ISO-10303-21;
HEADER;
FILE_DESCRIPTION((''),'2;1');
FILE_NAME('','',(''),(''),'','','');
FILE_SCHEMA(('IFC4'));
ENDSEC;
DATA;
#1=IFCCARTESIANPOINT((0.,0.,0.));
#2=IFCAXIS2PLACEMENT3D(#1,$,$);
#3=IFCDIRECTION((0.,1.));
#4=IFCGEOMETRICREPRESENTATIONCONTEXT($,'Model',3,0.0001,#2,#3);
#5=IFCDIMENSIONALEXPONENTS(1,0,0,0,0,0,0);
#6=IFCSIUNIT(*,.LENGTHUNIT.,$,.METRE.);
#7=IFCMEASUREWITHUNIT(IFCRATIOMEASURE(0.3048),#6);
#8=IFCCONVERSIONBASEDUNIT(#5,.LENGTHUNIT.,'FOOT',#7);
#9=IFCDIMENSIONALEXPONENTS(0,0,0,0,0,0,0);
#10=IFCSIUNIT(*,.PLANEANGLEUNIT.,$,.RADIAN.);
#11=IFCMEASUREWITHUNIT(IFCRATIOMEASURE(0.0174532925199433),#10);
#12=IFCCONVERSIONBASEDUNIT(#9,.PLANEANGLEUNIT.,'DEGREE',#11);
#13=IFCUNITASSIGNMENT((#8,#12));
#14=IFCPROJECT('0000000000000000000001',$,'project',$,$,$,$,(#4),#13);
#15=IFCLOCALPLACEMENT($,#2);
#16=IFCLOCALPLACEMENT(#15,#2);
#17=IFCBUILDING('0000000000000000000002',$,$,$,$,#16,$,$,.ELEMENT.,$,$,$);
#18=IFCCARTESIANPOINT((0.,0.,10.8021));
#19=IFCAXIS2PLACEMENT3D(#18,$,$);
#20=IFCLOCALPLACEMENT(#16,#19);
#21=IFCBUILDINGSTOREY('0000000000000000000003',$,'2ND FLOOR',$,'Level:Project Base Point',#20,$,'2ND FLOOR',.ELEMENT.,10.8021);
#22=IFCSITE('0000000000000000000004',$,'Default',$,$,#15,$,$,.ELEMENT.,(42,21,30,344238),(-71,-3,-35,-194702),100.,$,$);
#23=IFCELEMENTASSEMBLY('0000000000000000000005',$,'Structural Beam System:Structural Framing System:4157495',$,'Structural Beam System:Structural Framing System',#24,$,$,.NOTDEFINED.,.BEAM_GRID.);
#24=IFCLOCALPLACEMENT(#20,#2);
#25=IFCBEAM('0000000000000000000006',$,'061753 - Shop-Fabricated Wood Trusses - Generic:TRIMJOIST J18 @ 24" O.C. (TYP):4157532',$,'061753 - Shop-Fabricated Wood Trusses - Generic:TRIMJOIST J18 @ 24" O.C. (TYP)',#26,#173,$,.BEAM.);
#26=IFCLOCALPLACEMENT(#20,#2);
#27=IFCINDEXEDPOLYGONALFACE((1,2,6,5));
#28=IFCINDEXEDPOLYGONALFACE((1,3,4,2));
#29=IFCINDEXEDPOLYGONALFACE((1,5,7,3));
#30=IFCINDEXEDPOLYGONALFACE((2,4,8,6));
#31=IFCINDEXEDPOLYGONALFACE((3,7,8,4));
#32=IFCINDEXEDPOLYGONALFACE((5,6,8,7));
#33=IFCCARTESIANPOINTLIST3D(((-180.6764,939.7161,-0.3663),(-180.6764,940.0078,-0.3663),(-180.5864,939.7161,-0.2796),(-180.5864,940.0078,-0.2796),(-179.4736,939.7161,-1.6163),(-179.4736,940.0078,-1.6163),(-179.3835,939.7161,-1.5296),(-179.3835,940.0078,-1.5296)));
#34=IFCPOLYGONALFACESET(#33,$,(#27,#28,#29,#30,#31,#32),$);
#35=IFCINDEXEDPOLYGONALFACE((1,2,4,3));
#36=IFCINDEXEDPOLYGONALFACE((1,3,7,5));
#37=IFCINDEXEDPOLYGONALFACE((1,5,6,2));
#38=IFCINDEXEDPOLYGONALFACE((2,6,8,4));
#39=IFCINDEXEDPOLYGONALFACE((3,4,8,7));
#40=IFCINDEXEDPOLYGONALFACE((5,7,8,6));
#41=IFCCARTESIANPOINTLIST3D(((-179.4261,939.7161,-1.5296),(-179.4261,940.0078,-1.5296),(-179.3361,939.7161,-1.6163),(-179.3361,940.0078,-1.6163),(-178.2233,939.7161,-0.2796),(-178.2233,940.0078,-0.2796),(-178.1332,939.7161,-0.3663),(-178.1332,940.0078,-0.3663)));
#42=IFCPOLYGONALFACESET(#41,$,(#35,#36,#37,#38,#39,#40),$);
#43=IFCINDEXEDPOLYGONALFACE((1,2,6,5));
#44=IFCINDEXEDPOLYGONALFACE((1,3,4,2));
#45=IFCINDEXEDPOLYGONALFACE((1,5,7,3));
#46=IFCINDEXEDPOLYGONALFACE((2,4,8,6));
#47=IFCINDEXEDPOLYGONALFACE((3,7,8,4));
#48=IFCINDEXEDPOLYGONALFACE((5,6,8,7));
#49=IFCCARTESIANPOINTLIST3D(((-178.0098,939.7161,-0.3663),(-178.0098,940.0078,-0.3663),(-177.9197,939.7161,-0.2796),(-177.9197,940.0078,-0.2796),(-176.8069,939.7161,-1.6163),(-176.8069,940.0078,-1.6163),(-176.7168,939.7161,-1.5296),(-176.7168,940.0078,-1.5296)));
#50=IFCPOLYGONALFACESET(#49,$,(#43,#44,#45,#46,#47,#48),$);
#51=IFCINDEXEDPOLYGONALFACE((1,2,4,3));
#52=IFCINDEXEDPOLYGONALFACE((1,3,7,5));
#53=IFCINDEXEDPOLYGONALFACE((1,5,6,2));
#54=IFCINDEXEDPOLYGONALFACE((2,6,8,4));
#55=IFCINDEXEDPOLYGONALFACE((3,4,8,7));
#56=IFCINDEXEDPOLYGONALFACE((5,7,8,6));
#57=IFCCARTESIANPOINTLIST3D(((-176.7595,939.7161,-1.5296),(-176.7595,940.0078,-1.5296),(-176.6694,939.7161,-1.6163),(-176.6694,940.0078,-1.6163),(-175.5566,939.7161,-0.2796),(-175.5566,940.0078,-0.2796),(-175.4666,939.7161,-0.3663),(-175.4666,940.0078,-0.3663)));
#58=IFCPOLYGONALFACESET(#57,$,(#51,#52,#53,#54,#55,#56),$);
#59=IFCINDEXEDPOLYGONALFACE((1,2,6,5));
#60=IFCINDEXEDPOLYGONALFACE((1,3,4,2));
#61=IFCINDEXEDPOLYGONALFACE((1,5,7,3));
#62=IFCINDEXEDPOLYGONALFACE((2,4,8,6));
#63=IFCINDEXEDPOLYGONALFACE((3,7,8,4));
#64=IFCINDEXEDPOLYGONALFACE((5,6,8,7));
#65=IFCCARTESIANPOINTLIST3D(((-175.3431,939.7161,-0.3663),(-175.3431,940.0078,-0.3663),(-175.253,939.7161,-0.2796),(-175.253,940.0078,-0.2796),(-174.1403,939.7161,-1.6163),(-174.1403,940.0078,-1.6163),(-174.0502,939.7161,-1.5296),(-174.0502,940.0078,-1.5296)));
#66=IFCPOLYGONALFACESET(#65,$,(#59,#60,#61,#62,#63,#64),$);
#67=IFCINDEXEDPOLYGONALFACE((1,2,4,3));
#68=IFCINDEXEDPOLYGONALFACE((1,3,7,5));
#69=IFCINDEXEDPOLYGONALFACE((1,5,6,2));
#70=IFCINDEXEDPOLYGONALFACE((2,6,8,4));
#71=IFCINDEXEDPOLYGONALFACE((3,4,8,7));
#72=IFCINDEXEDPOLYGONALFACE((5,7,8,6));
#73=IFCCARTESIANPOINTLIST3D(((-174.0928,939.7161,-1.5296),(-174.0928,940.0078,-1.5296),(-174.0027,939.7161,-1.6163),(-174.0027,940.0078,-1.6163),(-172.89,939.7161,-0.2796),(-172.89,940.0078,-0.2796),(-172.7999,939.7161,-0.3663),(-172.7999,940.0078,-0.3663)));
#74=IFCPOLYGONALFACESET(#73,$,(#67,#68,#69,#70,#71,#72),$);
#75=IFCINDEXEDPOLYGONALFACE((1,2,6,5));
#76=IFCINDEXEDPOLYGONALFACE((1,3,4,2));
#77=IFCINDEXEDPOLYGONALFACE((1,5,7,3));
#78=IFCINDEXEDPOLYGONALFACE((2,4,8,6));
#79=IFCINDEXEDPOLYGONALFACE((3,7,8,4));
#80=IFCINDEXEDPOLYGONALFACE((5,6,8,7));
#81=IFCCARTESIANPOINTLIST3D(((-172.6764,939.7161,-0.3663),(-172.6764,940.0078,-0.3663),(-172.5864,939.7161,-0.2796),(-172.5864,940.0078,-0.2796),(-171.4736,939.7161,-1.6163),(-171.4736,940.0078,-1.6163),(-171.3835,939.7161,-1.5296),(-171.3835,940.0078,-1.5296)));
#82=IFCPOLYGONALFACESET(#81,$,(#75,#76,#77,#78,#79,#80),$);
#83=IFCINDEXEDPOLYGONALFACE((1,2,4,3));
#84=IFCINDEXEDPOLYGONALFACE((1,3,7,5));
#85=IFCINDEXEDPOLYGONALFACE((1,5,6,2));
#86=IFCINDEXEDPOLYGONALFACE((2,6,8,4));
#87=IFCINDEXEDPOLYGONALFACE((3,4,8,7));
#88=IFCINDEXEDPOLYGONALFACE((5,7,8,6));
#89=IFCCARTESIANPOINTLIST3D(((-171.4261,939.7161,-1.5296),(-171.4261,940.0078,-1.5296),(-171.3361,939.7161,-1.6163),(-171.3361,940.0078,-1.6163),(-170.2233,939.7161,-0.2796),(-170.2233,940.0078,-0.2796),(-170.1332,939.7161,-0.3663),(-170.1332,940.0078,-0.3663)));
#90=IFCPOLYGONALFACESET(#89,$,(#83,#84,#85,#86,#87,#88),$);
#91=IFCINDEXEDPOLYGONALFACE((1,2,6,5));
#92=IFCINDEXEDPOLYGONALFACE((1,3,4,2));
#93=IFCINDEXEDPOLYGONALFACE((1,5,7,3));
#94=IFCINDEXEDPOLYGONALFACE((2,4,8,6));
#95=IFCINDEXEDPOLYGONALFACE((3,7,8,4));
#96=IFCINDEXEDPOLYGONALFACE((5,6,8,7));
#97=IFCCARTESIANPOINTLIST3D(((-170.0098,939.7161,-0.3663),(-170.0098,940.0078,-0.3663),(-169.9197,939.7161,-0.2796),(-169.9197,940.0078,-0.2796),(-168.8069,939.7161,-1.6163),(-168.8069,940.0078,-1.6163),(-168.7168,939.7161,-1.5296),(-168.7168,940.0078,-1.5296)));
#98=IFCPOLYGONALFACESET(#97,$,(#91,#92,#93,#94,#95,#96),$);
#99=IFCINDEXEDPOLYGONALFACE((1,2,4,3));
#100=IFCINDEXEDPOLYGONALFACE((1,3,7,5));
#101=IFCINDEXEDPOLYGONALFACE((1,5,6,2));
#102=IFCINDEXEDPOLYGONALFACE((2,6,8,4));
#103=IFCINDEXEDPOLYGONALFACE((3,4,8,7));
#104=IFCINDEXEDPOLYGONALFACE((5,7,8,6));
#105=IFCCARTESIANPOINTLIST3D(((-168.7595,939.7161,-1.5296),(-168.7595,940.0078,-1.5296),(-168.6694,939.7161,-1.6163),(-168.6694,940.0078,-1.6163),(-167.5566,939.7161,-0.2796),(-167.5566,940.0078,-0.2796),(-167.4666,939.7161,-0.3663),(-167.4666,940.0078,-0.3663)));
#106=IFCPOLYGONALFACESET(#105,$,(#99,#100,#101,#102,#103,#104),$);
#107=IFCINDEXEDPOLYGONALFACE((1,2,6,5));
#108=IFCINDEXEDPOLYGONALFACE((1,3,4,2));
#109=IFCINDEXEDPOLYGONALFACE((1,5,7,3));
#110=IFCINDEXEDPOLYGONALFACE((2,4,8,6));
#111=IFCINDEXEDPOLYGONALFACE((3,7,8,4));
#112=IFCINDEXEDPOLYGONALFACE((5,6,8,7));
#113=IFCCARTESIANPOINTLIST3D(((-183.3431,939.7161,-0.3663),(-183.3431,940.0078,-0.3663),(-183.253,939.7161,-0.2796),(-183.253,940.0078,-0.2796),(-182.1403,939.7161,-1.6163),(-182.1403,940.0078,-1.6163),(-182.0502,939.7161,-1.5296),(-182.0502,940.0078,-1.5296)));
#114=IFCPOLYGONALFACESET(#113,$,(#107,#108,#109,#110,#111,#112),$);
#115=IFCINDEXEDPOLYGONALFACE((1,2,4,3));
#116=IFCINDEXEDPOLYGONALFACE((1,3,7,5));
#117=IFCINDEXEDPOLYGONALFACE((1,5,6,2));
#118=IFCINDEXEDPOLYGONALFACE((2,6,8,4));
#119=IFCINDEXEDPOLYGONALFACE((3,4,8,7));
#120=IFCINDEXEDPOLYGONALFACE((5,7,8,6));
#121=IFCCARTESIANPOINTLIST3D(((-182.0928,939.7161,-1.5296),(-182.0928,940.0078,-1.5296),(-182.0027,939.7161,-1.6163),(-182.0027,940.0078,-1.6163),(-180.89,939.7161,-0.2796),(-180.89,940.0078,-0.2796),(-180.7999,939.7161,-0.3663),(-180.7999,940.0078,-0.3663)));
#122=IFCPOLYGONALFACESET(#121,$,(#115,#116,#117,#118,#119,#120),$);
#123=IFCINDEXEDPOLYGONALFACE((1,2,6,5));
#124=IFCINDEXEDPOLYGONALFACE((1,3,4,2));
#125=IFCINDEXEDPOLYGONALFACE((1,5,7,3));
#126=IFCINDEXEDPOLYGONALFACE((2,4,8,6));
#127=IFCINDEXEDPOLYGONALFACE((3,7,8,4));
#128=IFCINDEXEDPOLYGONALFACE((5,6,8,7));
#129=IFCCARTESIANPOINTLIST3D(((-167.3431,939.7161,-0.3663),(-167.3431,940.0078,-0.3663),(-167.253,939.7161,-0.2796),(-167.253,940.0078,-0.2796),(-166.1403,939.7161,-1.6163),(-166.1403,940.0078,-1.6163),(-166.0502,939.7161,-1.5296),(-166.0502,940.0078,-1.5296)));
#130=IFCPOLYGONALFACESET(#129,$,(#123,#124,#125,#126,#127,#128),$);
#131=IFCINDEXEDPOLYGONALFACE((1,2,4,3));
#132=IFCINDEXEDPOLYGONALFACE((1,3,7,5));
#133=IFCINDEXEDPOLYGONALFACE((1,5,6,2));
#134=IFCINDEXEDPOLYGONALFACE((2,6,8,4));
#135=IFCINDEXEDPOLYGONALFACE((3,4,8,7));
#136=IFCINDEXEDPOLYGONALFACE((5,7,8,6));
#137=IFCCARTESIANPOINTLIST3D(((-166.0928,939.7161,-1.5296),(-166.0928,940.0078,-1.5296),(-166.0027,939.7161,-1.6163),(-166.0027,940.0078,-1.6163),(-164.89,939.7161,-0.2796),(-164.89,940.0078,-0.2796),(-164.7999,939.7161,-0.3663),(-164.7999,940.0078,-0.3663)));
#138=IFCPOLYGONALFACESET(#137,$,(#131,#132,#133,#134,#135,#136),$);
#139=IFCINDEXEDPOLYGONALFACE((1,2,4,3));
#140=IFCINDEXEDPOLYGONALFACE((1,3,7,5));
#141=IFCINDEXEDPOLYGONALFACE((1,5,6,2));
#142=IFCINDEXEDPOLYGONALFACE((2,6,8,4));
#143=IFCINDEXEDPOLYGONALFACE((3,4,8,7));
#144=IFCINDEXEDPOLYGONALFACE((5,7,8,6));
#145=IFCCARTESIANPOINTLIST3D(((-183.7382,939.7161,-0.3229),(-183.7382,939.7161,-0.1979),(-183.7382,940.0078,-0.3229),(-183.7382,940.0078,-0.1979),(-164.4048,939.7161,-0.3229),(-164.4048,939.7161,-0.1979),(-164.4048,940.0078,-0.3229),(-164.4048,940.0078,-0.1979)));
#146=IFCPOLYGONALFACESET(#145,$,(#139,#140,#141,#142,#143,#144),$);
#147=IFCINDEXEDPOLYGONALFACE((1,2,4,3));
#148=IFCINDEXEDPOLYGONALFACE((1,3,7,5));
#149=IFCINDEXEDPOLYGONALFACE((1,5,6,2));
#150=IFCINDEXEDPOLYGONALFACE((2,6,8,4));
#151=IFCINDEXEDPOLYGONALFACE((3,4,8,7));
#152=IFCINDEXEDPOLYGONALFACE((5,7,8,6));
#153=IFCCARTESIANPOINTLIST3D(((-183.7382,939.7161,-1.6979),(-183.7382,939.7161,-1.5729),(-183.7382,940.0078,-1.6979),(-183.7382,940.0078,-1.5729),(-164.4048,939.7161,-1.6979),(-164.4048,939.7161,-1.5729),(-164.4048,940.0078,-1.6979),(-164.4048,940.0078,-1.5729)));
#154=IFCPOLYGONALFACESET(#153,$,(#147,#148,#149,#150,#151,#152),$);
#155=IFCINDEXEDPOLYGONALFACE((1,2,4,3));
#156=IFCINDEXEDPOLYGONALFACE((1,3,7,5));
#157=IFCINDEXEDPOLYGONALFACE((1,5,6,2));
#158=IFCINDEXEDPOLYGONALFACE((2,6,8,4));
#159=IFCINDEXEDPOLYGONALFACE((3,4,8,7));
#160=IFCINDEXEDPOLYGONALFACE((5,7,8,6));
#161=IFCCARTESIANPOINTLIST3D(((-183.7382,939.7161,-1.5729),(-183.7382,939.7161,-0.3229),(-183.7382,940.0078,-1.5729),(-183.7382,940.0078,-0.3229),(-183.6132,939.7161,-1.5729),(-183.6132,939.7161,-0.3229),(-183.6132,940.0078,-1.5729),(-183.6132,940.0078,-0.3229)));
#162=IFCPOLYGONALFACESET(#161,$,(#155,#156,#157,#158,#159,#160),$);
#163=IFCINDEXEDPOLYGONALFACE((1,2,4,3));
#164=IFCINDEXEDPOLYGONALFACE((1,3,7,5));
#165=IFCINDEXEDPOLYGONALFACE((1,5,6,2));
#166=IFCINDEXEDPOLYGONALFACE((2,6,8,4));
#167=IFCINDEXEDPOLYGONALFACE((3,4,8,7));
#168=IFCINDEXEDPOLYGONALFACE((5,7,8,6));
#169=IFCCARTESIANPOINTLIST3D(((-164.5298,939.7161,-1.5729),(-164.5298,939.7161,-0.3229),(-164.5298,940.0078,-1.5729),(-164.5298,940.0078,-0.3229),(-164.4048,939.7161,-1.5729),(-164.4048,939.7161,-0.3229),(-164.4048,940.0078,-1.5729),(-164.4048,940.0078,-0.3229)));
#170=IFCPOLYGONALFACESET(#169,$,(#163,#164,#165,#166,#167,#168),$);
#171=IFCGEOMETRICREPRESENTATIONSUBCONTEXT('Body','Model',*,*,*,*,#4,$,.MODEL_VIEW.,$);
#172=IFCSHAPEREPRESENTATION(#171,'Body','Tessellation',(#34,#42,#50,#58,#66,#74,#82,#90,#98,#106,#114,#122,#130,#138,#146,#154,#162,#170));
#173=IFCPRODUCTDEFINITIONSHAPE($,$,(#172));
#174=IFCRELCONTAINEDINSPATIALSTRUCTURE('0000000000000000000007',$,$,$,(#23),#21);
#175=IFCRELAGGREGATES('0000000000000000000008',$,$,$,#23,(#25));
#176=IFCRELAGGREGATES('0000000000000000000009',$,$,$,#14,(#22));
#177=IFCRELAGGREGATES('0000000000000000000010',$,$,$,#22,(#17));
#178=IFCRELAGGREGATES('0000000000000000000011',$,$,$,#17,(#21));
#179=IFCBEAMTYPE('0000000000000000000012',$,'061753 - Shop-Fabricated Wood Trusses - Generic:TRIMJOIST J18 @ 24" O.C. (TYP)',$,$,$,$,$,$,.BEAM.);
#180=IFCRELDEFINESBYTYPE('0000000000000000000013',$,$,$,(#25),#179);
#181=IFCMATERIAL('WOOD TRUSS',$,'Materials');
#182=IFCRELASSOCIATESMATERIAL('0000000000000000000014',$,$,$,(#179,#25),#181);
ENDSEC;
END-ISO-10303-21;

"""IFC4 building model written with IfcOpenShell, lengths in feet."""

from ifc_helpers import new_model, entity, si_unit, converted_unit, direction, frame, frame_2d, origin, origin_2d_with_axis, place, context, subcontext, project, spatial, rectangle, extrude, source, transform, mapped, material, material_profile, profile_set, profile_usage, type_object, type_shapes, element, aggregate, save


model = new_model("IFC4")

# Units and contexts
model_context = context("Model", 3, precision=0.0001, world=origin(), true_north=direction((0.0, 1.0)))
body_context = subcontext(model_context, "Body", "Model", "MODEL_VIEW")
ifc_project = project(units=[converted_unit("LENGTHUNIT", "FOOT", entity("IfcRatioMeasure", 0.3048), si_unit("LENGTHUNIT", "METRE"), dimensions=[1, 0, 0, 0, 0, 0, 0]), converted_unit("PLANEANGLEUNIT", "DEGREE", entity("IfcRatioMeasure", 0.0174532925199433), si_unit("PLANEANGLEUNIT", "RADIAN"), dimensions=[0, 0, 0, 0, 0, 0, 0])], contexts=[model_context])

# Site, building, storey
site_placement = place(None, origin())
site = spatial("IfcSite", under=ifc_project, at=site_placement, Name="Default", CompositionType="ELEMENT", RefLatitude=(42, 21, 30, 344238), RefLongitude=(-71, -3, -35, -194702), RefElevation=100.0)
building_placement = place(site_placement, origin())
building = spatial("IfcBuilding", under=site, at=building_placement, CompositionType="ELEMENT")
storey_placement = place(building_placement, frame((0.0, 0.0, 10.8021)))
storey = spatial("IfcBuildingStorey", under=building, at=storey_placement, Name="2ND FLOOR", ObjectType="Level:Project Base Point", LongName="2ND FLOOR", CompositionType="ELEMENT", Elevation=10.8021)

# Element assembly, beam
ifc_material_1 = material(Name="WOOD TRUSS", Category="Materials")
ifc_material_profile_1 = material_profile(ifc_material_1, rectangle(XDim=1.7347, YDim=0.125, at=frame_2d((0.0, 0.0), x_axis=(1.0, 0.0))), Name="TRIMJOIST J18 @ 24\" O.C. (TYP)")
ifc_material_profile_2 = material_profile(ifc_material_1, rectangle(XDim=1.7347, YDim=0.125, at=frame_2d((0.0, 0.0), x_axis=(1.0, 0.0))), Name="TRIMJOIST J18 @ 24\" O.C. (TYP)")
ifc_material_profile_3 = material_profile(ifc_material_1, rectangle(XDim=1.7347, YDim=0.125, at=frame_2d((0.0, 0.0), x_axis=(1.0, 0.0))), Name="TRIMJOIST J18 @ 24\" O.C. (TYP)")
ifc_material_profile_4 = material_profile(ifc_material_1, rectangle(XDim=1.7347, YDim=0.125, at=frame_2d((0.0, 0.0), x_axis=(1.0, 0.0))), Name="TRIMJOIST J18 @ 24\" O.C. (TYP)")
ifc_material_profile_5 = material_profile(ifc_material_1, rectangle(XDim=1.7347, YDim=0.125, at=frame_2d((0.0, 0.0), x_axis=(1.0, 0.0))), Name="TRIMJOIST J18 @ 24\" O.C. (TYP)")
ifc_material_profile_6 = material_profile(ifc_material_1, rectangle(XDim=1.7347, YDim=0.125, at=frame_2d((0.0, 0.0), x_axis=(1.0, 0.0))), Name="TRIMJOIST J18 @ 24\" O.C. (TYP)")
ifc_material_profile_7 = material_profile(ifc_material_1, rectangle(XDim=1.7347, YDim=0.125, at=frame_2d((0.0, 0.0), x_axis=(1.0, 0.0))), Name="TRIMJOIST J18 @ 24\" O.C. (TYP)")
ifc_material_profile_8 = material_profile(ifc_material_1, rectangle(XDim=1.7347, YDim=0.125, at=frame_2d((0.0, 0.0), x_axis=(1.0, 0.0))), Name="TRIMJOIST J18 @ 24\" O.C. (TYP)")
ifc_material_profile_9 = material_profile(ifc_material_1, rectangle(XDim=1.7347, YDim=0.125, at=frame_2d((0.0, 0.0), x_axis=(1.0, 0.0))), Name="TRIMJOIST J18 @ 24\" O.C. (TYP)")
ifc_material_profile_10 = material_profile(ifc_material_1, rectangle(XDim=1.7347, YDim=0.125, at=origin_2d_with_axis()), Name="TRIMJOIST J18 @ 24\" O.C. (TYP)")
ifc_material_profile_11 = material_profile(ifc_material_1, rectangle(XDim=0.125, YDim=0.2917, at=origin_2d_with_axis()), Name="TRIMJOIST J18 @ 24\" O.C. (TYP)")
ifc_material_profile_12 = material_profile(ifc_material_1, rectangle(XDim=0.125, YDim=0.2917, at=origin_2d_with_axis()), Name="TRIMJOIST J18 @ 24\" O.C. (TYP)")
ifc_material_profile_13 = material_profile(ifc_material_1, rectangle(XDim=1.25, YDim=0.2917, at=origin_2d_with_axis()), Name="TRIMJOIST J18 @ 24\" O.C. (TYP)")
ifc_material_profile_14 = material_profile(ifc_material_1, rectangle(XDim=1.25, YDim=0.2917, at=origin_2d_with_axis()), Name="TRIMJOIST J18 @ 24\" O.C. (TYP)")
ifc_profile_set_1 = profile_set([ifc_material_profile_1, ifc_material_profile_2, ifc_material_profile_3, ifc_material_profile_4, ifc_material_profile_5, ifc_material_profile_6, ifc_material_profile_7, ifc_material_profile_8, ifc_material_profile_9, ifc_material_profile_10, ifc_material_profile_11, ifc_material_profile_12, ifc_material_profile_13, ifc_material_profile_14], Name="TRIMJOIST J18 @ 24\" O.C. (TYP)")
assembly_1_placement = place(storey_placement, origin())
assembly_1 = element("IfcElementAssembly", 1, at=assembly_1_placement, inside=storey, Name="Structural Beam System:Structural Framing System:4157495", ObjectType="Structural Beam System:Structural Framing System", AssemblyPlace="NOTDEFINED", PredefinedType="BEAM_GRID")
ifc_profile_usage_1 = profile_usage(ifc_profile_set_1, cardinal=8)
beam_type_1 = type_object("IfcBeamType", Name="061753 - Shop-Fabricated Wood Trusses - Generic:TRIMJOIST J18 @ 24\" O.C. (TYP)", PredefinedType="BEAM", material=ifc_profile_set_1)
shared_shape_1 = source(origin(), body_context, "Body", "SweptSolid", [
    extrude(rectangle(XDim=1.7347, YDim=0.125, at=frame_2d((0.0, 0.0), x_axis=(1.0, 0.0))), frame((5.9585, -0.1458, 0.0), z_axis=(0.0, 1.0, 0.0), x_axis=(0.693383, 0.0, 0.720569)), (0.0, 0.0, 1.0), 0.2917),
    extrude(rectangle(XDim=1.7347, YDim=0.125, at=origin_2d_with_axis()), frame((4.7082, -0.1458, 0.0), z_axis=(0.0, 1.0, 0.0), x_axis=(0.693383, 0.0, -0.720569)), (0.0, 0.0, 1.0), 0.2917),
    extrude(rectangle(XDim=1.7347, YDim=0.125, at=frame_2d((0.0, 0.0), x_axis=(1.0, 0.0))), frame((3.2918, -0.1458, 0.0), z_axis=(0.0, 1.0, 0.0), x_axis=(0.693383, 0.0, 0.720569)), (0.0, 0.0, 1.0), 0.2917),
    extrude(rectangle(XDim=1.7347, YDim=0.125, at=frame_2d((0.0, 0.0), x_axis=(1.0, 0.0))), frame((2.0415, -0.1458, 0.0), z_axis=(0.0, 1.0, 0.0), x_axis=(0.693383, 0.0, -0.720569)), (0.0, 0.0, 1.0), 0.2917),
    extrude(rectangle(XDim=1.7347, YDim=0.125, at=frame_2d((0.0, 0.0), x_axis=(1.0, 0.0))), frame((0.6251, -0.1458, 0.0), z_axis=(0.0, 1.0, 0.0), x_axis=(0.693383, 0.0, 0.720569)), (0.0, 0.0, 1.0), 0.2917),
    extrude(rectangle(XDim=1.7347, YDim=0.125, at=frame_2d((0.0, 0.0), x_axis=(1.0, 0.0))), frame((-0.6251, -0.1458, 0.0), z_axis=(0.0, 1.0, 0.0), x_axis=(0.693383, 0.0, -0.720569)), (0.0, 0.0, 1.0), 0.2917),
    extrude(rectangle(XDim=1.7347, YDim=0.125, at=frame_2d((0.0, 0.0), x_axis=(1.0, 0.0))), frame((-2.0415, -0.1458, 0.0), z_axis=(0.0, 1.0, 0.0), x_axis=(0.693383, 0.0, 0.720569)), (0.0, 0.0, 1.0), 0.2917),
    extrude(rectangle(XDim=1.7347, YDim=0.125, at=origin_2d_with_axis()), frame((-3.2918, -0.1458, 0.0), z_axis=(0.0, 1.0, 0.0), x_axis=(0.693383, 0.0, -0.720569)), (0.0, 0.0, 1.0), 0.2917),
    extrude(rectangle(XDim=1.7347, YDim=0.125, at=frame_2d((0.0, 0.0), x_axis=(1.0, 0.0))), frame((-4.7082, -0.1458, 0.0), z_axis=(0.0, 1.0, 0.0), x_axis=(0.693383, 0.0, 0.720569)), (0.0, 0.0, 1.0), 0.2917),
    extrude(rectangle(XDim=1.7347, YDim=0.125, at=frame_2d((0.0, 0.0), x_axis=(1.0, 0.0))), frame((-5.9585, -0.1458, 0.0), z_axis=(0.0, 1.0, 0.0), x_axis=(0.693383, 0.0, -0.720569)), (0.0, 0.0, 1.0), 0.2917),
    extrude(rectangle(XDim=1.7347, YDim=0.125, at=frame_2d((0.0, 0.0), x_axis=(1.0, 0.0))), frame((8.6251, -0.1458, 0.0), z_axis=(0.0, 1.0, 0.0), x_axis=(0.693383, 0.0, 0.720569)), (0.0, 0.0, 1.0), 0.2917),
    extrude(rectangle(XDim=1.7347, YDim=0.125, at=origin_2d_with_axis()), frame((7.3749, -0.1458, 0.0), z_axis=(0.0, 1.0, 0.0), x_axis=(0.693383, 0.0, -0.720569)), (0.0, 0.0, 1.0), 0.2917),
    extrude(rectangle(XDim=1.7347, YDim=0.125, at=frame_2d((0.0, 0.0), x_axis=(1.0, 0.0))), frame((-7.3749, -0.1458, 0.0), z_axis=(0.0, 1.0, 0.0), x_axis=(0.693383, 0.0, 0.720569)), (0.0, 0.0, 1.0), 0.2917),
    extrude(rectangle(XDim=1.7347, YDim=0.125, at=origin_2d_with_axis()), frame((-8.6251, -0.1458, 0.0), z_axis=(0.0, 1.0, 0.0), x_axis=(0.693383, 0.0, -0.720569)), (0.0, 0.0, 1.0), 0.2917),
    extrude(rectangle(XDim=0.125, YDim=0.2917, at=origin_2d_with_axis()), frame((-9.6667, 0.0, 0.6875), z_axis=(1.0, 0.0, 0.0), x_axis=(0.0, 0.0, -1.0)), (0.0, 0.0, 1.0), 19.3333),
    extrude(rectangle(XDim=0.125, YDim=0.2917, at=origin_2d_with_axis()), frame((-9.6667, 0.0, -0.6875), z_axis=(1.0, 0.0, 0.0), x_axis=(0.0, 0.0, -1.0)), (0.0, 0.0, 1.0), 19.3333),
    extrude(rectangle(XDim=1.25, YDim=0.2917, at=origin_2d_with_axis()), frame((9.5417, 0.0, 0.0), z_axis=(1.0, 0.0, 0.0), x_axis=(0.0, 0.0, -1.0)), (0.0, 0.0, 1.0), 0.125),
    extrude(rectangle(XDim=1.25, YDim=0.2917, at=origin_2d_with_axis()), frame((-9.6667, 0.0, 0.0), z_axis=(1.0, 0.0, 0.0), x_axis=(0.0, 0.0, -1.0)), (0.0, 0.0, 1.0), 0.125),
])
type_shapes(beam_type_1, [shared_shape_1])
beam_1_placement = place(assembly_1_placement, frame((-174.0715, 939.8619, -0.9479), z_axis=(0.0, 0.0, 1.0), x_axis=(-1.0, 0.0, 0.0)))
beam_1 = element("IfcBeam", 2, at=beam_1_placement, type_object=beam_type_1, material=ifc_profile_usage_1, Name="061753 - Shop-Fabricated Wood Trusses - Generic:TRIMJOIST J18 @ 24\" O.C. (TYP):4157532", ObjectType="061753 - Shop-Fabricated Wood Trusses - Generic:TRIMJOIST J18 @ 24\" O.C. (TYP)", PredefinedType="BEAM", context=body_context, shape_type="MappedRepresentation", body=[
    mapped(shared_shape_1, transform((0.0, 0.0, 0.0), scale=1.0)),
])
aggregate(assembly_1, [beam_1])

save(model, "model.ifc")
